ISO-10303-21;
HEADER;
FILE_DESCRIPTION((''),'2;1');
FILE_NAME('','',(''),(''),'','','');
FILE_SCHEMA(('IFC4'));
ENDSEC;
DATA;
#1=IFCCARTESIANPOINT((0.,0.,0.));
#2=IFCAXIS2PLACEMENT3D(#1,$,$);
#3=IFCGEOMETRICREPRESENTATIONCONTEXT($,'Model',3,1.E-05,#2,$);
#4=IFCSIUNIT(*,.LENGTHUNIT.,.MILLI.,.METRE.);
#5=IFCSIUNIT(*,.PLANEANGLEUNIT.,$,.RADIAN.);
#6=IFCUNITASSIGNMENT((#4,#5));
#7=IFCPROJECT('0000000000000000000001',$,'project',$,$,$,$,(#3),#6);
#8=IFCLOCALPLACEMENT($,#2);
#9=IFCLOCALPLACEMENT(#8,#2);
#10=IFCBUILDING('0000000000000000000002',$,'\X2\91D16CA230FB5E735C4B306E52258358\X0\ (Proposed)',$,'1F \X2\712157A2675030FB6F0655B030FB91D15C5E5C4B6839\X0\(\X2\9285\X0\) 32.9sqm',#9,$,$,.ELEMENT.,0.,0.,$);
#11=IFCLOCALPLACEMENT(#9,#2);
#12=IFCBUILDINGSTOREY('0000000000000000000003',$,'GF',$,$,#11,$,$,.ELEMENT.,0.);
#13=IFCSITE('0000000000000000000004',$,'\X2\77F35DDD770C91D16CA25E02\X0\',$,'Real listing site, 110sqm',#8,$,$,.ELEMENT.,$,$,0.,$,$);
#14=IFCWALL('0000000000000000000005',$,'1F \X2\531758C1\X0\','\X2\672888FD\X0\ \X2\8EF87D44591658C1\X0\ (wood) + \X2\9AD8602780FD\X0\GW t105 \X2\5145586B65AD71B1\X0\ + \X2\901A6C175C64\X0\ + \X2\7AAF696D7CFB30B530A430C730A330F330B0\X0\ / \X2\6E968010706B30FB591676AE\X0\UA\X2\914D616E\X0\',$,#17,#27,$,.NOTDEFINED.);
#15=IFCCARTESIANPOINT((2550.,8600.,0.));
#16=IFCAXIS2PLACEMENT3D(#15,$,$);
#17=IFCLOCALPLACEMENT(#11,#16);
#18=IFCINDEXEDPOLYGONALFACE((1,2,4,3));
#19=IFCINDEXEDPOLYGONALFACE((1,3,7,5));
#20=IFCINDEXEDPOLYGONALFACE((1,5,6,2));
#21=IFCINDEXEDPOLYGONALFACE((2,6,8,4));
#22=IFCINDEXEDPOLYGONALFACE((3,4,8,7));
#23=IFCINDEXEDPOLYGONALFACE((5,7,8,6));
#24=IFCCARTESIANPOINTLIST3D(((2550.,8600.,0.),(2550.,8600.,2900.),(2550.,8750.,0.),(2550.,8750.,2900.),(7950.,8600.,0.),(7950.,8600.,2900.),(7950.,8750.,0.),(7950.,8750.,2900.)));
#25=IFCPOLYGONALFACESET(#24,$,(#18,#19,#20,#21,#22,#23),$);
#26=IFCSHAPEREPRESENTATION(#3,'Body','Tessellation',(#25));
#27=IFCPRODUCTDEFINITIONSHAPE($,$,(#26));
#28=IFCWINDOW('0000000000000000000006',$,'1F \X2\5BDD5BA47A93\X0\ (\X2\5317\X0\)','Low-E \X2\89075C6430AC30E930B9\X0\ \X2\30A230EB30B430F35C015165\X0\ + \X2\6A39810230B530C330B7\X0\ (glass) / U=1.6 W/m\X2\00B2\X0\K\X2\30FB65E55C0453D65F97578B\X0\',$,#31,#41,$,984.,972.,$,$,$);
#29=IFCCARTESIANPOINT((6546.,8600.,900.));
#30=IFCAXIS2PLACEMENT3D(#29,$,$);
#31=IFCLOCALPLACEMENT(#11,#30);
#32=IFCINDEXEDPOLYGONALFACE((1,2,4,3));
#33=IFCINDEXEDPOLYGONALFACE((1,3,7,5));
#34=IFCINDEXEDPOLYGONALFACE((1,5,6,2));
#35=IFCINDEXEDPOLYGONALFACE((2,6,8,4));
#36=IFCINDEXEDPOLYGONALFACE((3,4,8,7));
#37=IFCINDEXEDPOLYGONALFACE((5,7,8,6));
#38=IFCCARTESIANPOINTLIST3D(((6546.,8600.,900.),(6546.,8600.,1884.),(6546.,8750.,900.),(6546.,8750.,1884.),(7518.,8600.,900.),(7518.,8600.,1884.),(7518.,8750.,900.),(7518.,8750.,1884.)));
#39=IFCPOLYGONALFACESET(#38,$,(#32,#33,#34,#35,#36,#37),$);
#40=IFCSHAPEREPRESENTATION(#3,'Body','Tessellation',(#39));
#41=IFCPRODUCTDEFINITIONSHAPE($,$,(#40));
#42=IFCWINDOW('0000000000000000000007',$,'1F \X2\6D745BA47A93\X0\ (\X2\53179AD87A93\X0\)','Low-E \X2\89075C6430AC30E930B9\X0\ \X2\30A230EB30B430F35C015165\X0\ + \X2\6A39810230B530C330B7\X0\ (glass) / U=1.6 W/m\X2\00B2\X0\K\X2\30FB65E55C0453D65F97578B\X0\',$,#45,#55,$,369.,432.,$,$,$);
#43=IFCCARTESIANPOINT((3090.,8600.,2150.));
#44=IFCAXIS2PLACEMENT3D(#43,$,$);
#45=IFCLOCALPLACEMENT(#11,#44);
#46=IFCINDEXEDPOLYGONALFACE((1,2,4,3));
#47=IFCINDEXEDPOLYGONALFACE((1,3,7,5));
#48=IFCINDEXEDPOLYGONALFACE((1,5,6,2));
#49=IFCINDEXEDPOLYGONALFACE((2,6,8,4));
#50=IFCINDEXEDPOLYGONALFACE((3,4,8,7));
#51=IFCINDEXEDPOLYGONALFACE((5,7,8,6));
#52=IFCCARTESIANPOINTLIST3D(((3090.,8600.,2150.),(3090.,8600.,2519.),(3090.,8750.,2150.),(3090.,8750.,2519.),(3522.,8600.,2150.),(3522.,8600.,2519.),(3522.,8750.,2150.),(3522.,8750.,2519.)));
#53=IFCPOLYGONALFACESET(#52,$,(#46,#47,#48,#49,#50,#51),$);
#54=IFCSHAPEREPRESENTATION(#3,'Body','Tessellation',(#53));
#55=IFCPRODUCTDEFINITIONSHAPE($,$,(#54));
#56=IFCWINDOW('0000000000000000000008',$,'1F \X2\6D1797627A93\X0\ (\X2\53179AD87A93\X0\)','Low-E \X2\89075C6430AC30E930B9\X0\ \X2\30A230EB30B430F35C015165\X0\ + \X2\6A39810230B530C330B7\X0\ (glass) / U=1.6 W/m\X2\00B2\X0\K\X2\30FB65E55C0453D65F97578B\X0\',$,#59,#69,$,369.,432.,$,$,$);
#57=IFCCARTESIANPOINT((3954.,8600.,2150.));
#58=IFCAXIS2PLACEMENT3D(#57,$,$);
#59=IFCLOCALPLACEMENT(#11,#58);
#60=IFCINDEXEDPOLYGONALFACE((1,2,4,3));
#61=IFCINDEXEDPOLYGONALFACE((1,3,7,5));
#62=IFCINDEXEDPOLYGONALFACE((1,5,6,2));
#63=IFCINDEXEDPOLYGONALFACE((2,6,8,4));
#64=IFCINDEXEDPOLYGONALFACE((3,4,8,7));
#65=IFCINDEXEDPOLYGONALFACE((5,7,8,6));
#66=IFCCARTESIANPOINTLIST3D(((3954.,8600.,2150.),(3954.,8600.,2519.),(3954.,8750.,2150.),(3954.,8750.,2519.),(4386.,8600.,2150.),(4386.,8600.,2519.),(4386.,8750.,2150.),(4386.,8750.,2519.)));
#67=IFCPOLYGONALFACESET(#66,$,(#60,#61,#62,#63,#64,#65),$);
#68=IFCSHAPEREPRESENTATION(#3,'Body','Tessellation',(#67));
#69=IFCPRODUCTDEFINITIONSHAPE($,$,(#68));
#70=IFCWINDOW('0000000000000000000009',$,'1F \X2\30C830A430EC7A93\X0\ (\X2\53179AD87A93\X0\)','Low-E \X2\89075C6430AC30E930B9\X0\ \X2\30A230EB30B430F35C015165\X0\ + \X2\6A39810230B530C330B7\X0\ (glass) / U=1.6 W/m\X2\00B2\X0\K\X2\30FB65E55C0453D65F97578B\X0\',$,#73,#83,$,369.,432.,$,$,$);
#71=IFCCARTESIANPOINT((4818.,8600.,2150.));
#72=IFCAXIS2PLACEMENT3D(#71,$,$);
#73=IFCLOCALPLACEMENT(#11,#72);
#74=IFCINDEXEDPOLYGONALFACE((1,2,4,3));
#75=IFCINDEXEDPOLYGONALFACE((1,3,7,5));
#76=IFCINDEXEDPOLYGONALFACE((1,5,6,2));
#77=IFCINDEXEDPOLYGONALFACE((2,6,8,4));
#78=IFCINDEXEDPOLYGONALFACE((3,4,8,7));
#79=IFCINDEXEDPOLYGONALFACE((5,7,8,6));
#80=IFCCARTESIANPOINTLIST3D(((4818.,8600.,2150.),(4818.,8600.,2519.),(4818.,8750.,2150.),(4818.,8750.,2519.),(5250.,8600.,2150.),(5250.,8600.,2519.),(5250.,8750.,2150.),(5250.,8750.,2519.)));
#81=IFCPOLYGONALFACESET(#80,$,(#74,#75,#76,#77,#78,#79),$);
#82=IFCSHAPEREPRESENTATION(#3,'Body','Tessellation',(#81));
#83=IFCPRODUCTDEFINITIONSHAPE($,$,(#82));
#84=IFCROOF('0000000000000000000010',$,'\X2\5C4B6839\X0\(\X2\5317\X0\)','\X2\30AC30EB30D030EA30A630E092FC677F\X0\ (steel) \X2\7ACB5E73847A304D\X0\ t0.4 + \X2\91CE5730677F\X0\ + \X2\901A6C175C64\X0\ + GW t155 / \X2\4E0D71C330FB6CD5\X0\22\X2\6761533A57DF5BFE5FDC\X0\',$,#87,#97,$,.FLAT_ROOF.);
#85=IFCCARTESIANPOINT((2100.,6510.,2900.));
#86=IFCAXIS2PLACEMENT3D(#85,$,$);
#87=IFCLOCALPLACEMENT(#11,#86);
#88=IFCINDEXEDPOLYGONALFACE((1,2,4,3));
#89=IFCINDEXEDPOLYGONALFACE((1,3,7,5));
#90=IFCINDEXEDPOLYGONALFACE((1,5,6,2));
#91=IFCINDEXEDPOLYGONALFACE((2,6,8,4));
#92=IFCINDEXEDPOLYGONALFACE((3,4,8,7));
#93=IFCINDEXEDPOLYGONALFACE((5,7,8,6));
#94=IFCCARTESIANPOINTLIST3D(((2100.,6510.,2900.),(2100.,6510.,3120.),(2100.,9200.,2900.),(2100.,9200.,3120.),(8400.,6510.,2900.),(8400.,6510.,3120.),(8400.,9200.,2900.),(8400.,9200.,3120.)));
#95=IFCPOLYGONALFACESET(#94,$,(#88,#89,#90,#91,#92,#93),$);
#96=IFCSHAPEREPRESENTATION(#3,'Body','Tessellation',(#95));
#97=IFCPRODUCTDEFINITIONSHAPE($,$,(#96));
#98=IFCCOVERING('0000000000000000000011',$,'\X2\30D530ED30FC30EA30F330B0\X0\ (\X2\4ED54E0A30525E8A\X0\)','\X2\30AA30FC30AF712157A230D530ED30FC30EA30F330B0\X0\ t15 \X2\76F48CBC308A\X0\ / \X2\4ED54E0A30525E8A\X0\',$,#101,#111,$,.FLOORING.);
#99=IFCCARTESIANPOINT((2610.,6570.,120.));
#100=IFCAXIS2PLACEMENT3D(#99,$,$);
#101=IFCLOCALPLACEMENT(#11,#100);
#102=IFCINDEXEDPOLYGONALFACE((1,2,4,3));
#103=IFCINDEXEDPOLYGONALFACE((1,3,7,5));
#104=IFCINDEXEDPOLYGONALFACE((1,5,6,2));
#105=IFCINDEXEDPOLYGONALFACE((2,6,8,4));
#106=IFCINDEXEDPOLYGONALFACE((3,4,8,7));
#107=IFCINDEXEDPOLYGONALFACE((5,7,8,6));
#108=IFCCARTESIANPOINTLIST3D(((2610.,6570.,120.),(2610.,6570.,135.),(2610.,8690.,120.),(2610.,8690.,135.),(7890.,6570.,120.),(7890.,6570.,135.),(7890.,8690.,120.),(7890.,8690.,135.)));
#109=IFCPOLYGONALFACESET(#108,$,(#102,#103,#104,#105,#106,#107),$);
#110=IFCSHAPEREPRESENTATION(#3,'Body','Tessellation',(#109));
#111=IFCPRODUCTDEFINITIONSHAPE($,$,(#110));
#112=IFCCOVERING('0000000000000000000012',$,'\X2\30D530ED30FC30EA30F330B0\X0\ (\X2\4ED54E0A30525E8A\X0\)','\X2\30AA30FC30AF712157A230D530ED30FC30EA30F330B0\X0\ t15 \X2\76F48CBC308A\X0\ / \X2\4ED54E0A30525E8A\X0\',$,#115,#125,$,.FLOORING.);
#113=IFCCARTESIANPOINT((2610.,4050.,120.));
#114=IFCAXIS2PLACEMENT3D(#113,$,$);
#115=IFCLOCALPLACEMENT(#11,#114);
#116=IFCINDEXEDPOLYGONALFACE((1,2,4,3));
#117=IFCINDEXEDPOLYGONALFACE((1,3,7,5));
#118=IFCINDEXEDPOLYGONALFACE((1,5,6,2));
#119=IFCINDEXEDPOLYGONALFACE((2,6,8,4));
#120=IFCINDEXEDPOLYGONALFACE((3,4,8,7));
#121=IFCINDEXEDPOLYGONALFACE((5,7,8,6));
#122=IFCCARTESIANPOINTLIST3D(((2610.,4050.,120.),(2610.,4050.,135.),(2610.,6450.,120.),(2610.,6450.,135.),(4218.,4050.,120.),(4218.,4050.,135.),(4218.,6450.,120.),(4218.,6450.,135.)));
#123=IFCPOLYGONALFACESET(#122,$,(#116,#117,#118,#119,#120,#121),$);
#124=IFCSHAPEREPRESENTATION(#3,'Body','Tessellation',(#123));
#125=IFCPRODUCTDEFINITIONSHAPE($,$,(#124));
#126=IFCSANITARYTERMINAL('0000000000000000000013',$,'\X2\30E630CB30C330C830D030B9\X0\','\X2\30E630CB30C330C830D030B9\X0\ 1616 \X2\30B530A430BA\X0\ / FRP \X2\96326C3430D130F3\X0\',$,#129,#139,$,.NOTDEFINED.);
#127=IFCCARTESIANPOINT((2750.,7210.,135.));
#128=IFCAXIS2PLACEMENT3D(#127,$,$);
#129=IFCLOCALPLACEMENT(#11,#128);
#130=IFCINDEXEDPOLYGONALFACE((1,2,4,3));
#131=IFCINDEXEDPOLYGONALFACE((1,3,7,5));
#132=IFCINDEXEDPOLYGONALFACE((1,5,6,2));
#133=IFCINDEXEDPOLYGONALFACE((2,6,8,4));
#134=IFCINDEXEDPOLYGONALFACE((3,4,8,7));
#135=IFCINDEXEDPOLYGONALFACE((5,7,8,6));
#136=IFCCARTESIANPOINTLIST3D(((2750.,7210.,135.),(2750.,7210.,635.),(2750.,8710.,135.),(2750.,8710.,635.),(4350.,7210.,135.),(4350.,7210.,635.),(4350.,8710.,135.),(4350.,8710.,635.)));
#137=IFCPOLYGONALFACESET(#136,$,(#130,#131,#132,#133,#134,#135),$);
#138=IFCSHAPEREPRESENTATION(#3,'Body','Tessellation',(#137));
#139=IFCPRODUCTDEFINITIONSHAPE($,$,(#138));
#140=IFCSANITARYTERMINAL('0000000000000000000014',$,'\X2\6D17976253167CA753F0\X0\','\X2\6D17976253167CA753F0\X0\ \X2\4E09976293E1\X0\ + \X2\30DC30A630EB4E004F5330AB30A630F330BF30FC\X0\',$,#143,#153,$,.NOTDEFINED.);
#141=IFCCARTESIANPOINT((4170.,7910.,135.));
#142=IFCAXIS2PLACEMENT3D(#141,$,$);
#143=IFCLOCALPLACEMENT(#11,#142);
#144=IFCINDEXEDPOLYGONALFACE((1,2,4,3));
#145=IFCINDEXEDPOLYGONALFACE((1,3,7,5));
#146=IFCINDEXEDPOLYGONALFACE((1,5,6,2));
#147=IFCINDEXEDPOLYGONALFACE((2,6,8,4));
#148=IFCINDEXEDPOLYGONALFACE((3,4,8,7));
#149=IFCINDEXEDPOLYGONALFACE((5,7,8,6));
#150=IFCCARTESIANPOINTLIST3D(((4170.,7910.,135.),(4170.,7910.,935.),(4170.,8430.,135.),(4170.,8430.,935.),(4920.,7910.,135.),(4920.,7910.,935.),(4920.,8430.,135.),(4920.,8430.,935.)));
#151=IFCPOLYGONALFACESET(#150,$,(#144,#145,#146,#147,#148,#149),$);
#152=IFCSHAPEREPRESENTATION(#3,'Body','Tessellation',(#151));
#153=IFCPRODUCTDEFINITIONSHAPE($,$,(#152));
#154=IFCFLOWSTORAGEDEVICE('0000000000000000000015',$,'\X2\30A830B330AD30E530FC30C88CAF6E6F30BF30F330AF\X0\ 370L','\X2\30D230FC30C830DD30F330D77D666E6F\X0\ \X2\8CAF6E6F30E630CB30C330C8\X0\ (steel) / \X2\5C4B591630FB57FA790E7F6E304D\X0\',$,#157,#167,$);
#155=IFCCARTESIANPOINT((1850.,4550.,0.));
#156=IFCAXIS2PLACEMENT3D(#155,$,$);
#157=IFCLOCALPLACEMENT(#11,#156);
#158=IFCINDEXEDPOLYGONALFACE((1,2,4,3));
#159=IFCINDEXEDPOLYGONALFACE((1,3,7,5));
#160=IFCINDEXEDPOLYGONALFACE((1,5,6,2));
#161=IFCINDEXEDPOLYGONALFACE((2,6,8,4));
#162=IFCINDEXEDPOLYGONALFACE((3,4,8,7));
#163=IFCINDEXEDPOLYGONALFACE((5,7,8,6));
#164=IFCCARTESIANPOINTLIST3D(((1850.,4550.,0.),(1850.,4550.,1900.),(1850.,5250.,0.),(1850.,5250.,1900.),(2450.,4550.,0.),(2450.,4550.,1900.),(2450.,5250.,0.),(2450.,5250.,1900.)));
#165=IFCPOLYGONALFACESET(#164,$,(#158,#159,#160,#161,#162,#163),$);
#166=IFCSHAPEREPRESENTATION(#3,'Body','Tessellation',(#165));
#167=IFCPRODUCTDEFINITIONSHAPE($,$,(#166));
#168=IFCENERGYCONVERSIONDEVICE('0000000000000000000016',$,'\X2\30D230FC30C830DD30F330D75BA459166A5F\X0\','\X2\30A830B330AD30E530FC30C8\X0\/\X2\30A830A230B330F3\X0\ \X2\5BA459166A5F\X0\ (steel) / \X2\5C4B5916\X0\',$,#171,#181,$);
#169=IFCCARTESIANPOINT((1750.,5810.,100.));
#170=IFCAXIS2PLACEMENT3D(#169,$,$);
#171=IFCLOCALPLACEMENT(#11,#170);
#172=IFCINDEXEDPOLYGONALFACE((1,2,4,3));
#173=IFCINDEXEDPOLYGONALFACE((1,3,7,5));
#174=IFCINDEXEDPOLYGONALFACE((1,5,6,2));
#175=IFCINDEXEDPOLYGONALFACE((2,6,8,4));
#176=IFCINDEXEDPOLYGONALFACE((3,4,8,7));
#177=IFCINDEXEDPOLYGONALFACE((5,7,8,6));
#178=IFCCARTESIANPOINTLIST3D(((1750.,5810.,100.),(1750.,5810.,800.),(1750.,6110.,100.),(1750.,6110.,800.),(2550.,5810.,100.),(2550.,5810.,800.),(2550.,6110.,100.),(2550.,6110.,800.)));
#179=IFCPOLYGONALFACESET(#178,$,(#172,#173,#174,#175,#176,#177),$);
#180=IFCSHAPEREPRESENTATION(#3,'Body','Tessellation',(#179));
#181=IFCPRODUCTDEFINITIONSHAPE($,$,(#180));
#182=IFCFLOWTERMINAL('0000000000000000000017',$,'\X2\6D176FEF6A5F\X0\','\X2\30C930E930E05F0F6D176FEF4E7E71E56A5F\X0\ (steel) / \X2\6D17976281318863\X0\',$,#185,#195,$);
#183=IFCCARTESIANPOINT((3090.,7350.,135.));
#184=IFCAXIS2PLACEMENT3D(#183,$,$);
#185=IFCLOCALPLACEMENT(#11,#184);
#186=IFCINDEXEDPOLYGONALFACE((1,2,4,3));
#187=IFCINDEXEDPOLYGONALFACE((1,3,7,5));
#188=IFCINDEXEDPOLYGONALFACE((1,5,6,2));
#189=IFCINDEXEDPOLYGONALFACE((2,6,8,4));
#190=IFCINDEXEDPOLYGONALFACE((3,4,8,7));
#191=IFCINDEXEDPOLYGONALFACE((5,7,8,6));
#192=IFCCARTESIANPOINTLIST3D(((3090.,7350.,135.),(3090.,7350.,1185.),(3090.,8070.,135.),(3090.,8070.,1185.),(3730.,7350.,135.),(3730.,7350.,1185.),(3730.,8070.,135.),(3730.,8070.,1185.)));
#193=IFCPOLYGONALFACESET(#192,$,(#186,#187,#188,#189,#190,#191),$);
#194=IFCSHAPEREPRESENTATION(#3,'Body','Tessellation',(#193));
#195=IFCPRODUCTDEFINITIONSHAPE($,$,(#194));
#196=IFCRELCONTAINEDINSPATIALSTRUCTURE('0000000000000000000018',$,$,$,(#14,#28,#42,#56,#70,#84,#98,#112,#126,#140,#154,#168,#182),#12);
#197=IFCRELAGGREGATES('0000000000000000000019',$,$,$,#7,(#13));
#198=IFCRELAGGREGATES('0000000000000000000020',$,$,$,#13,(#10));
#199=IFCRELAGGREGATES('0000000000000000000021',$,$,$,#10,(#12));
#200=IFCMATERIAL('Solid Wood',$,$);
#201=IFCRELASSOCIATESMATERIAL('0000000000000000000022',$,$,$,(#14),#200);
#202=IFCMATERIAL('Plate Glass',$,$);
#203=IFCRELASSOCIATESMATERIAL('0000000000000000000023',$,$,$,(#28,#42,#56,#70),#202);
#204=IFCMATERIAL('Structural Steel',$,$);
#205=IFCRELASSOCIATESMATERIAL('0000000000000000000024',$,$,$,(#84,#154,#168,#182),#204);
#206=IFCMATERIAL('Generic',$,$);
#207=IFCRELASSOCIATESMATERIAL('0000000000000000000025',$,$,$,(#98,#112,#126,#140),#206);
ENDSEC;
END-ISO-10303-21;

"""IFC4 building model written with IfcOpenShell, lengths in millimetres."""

from ifc_helpers import new_model, si_unit, frame, frame_2d, origin, place, context, project, spatial, rectangle, extrude, material, element, fill, save


model = new_model("IFC4")

# Units and contexts
model_context = context("Model", 3, precision=1e-05, world=origin())
ifc_project = project(units=[si_unit("LENGTHUNIT", "METRE", prefix="MILLI"), si_unit("PLANEANGLEUNIT", "RADIAN")], contexts=[model_context])

# Site, building, storey
site_placement = place(None, origin())
site = spatial("IfcSite", under=ifc_project, at=site_placement, Name="石川県金沢市", ObjectType="Real listing site, 110sqm", CompositionType="ELEMENT", RefElevation=0.0)
building_placement = place(site_placement, origin())
building = spatial("IfcBuilding", under=site, at=building_placement, Name="金沢・平屋の別荘 (Proposed)", ObjectType="1F 無垢材・漆喰・金属屋根(銅) 32.9sqm", CompositionType="ELEMENT", ElevationOfRefHeight=0.0, ElevationOfTerrain=0.0)
storey_placement = place(building_placement, origin())
storey = spatial("IfcBuildingStorey", under=building, at=storey_placement, Name="GF", CompositionType="ELEMENT", Elevation=0.0)

# Shared definitions
ifc_material_1 = material(Name="Solid Wood")

# Wall, openings, windows
wall_1_placement = place(storey_placement, frame((2550.0, 8600.0, 0.0)))
wall_1 = element("IfcWall", 1, at=wall_1_placement, inside=storey, material=ifc_material_1, Name="1F 北壁", Description="木製 軸組外壁 (wood) + 高性能GW t105 充填断熱 + 通気層 + 窯業系サイディング / 準耐火・外皮UA配慮", PredefinedType="NOTDEFINED", context=model_context, shape_type="SweptSolid", body=[
    extrude(rectangle(XDim=5400.0, YDim=150.0, at=frame_2d((2700.0, 75.0))), frame((2550.0, 8600.0, 0.0)), (0.0, 0.0, 1.0), 2900.0),
])
opening_1_placement = place(storey_placement, frame((6546.0, 8600.0, 900.0)))
opening_1 = element("IfcOpeningElement", 2, at=opening_1_placement, cuts=wall_1, PredefinedType="NOTDEFINED", context=model_context, shape_type="SweptSolid", body=[
    extrude(rectangle(XDim=972.0, YDim=150.0, at=frame_2d((486.0, 75.0))), frame((6546.0, 8600.0, 900.0)), (0.0, 0.0, 1.0), 984.0),
])
opening_2_placement = place(storey_placement, frame((3090.0, 8600.0, 2150.0)))
opening_2 = element("IfcOpeningElement", 3, at=opening_2_placement, cuts=wall_1, PredefinedType="NOTDEFINED", context=model_context, shape_type="SweptSolid", body=[
    extrude(rectangle(XDim=432.0, YDim=150.0, at=frame_2d((216.0, 75.0))), frame((3090.0, 8600.0, 2150.0)), (0.0, 0.0, 1.0), 369.0),
])
opening_3_placement = place(storey_placement, frame((3954.0, 8600.0, 2150.0)))
opening_3 = element("IfcOpeningElement", 4, at=opening_3_placement, cuts=wall_1, PredefinedType="NOTDEFINED", context=model_context, shape_type="SweptSolid", body=[
    extrude(rectangle(XDim=432.0, YDim=150.0, at=frame_2d((216.0, 75.0))), frame((3954.0, 8600.0, 2150.0)), (0.0, 0.0, 1.0), 369.0),
])
opening_4_placement = place(storey_placement, frame((4818.0, 8600.0, 2150.0)))
opening_4 = element("IfcOpeningElement", 5, at=opening_4_placement, cuts=wall_1, PredefinedType="NOTDEFINED", context=model_context, shape_type="SweptSolid", body=[
    extrude(rectangle(XDim=432.0, YDim=150.0, at=frame_2d((216.0, 75.0))), frame((4818.0, 8600.0, 2150.0)), (0.0, 0.0, 1.0), 369.0),
])
ifc_material_2 = material(Name="Plate Glass")
window_1_placement = place(storey_placement, frame((6546.0, 8600.0, 900.0)))
window_1 = element("IfcWindow", 6, at=window_1_placement, inside=storey, material=ifc_material_2, Name="1F 寝室窓 (北)", Description="Low-E 複層ガラス アルゴン封入 + 樹脂サッシ (glass) / U=1.6 W/m²K・日射取得型", OverallHeight=984.0, OverallWidth=972.0, context=model_context, shape_type="SweptSolid", body=[
    extrude(rectangle(XDim=972.0, YDim=150.0, at=frame_2d((486.0, 75.0))), frame((6546.0, 8600.0, 900.0)), (0.0, 0.0, 1.0), 984.0),
])
fill(opening_1, window_1)
window_2_placement = place(storey_placement, frame((3090.0, 8600.0, 2150.0)))
window_2 = element("IfcWindow", 7, at=window_2_placement, inside=storey, material=ifc_material_2, Name="1F 浴室窓 (北高窓)", Description="Low-E 複層ガラス アルゴン封入 + 樹脂サッシ (glass) / U=1.6 W/m²K・日射取得型", OverallHeight=369.0, OverallWidth=432.0, context=model_context, shape_type="SweptSolid", body=[
    extrude(rectangle(XDim=432.0, YDim=150.0, at=frame_2d((216.0, 75.0))), frame((3090.0, 8600.0, 2150.0)), (0.0, 0.0, 1.0), 369.0),
])
fill(opening_2, window_2)
window_3_placement = place(storey_placement, frame((3954.0, 8600.0, 2150.0)))
window_3 = element("IfcWindow", 8, at=window_3_placement, inside=storey, material=ifc_material_2, Name="1F 洗面窓 (北高窓)", Description="Low-E 複層ガラス アルゴン封入 + 樹脂サッシ (glass) / U=1.6 W/m²K・日射取得型", OverallHeight=369.0, OverallWidth=432.0, context=model_context, shape_type="SweptSolid", body=[
    extrude(rectangle(XDim=432.0, YDim=150.0, at=frame_2d((216.0, 75.0))), frame((3954.0, 8600.0, 2150.0)), (0.0, 0.0, 1.0), 369.0),
])
fill(opening_3, window_3)
window_4_placement = place(storey_placement, frame((4818.0, 8600.0, 2150.0)))
window_4 = element("IfcWindow", 9, at=window_4_placement, inside=storey, material=ifc_material_2, Name="1F トイレ窓 (北高窓)", Description="Low-E 複層ガラス アルゴン封入 + 樹脂サッシ (glass) / U=1.6 W/m²K・日射取得型", OverallHeight=369.0, OverallWidth=432.0, context=model_context, shape_type="SweptSolid", body=[
    extrude(rectangle(XDim=432.0, YDim=150.0, at=frame_2d((216.0, 75.0))), frame((4818.0, 8600.0, 2150.0)), (0.0, 0.0, 1.0), 369.0),
])
fill(opening_4, window_4)

# Roof
ifc_material_3 = material(Name="Structural Steel")
roof_placement = place(storey_placement, frame((2100.0, 6510.0, 2900.0)))
element("IfcRoof", 10, at=roof_placement, inside=storey, material=ifc_material_3, Name="屋根(北)", Description="ガルバリウム鋼板 (steel) 立平葺き t0.4 + 野地板 + 通気層 + GW t155 / 不燃・法22条区域対応", PredefinedType="FLAT_ROOF", context=model_context, shape_type="SweptSolid", body=[
    extrude(rectangle(XDim=6300.0, YDim=2690.0, at=frame_2d((3150.0, 1345.0))), frame((2100.0, 6510.0, 2900.0)), (0.0, 0.0, 1.0), 220.0),
])

# Coverings
ifc_material_4 = material(Name="Generic")
covering_1_placement = place(storey_placement, frame((2610.0, 6570.0, 120.0)))
element("IfcCovering", 11, at=covering_1_placement, inside=storey, material=ifc_material_4, Name="フローリング (仕上げ床)", Description="オーク無垢フローリング t15 直貼り / 仕上げ床", PredefinedType="FLOORING", context=model_context, shape_type="SweptSolid", body=[
    extrude(rectangle(XDim=5280.0, YDim=2120.0, at=frame_2d((2640.0, 1060.0))), frame((2610.0, 6570.0, 120.0)), (0.0, 0.0, 1.0), 15.0),
])
covering_2_placement = place(storey_placement, frame((2610.0, 4050.0, 120.0)))
element("IfcCovering", 12, at=covering_2_placement, inside=storey, material=ifc_material_4, Name="フローリング (仕上げ床)", Description="オーク無垢フローリング t15 直貼り / 仕上げ床", PredefinedType="FLOORING", context=model_context, shape_type="SweptSolid", body=[
    extrude(rectangle(XDim=1608.0, YDim=2400.0, at=frame_2d((804.0, 1200.0))), frame((2610.0, 4050.0, 120.0)), (0.0, 0.0, 1.0), 15.0),
])

# Sanitary terminals
sanitary_terminal_1_placement = place(storey_placement, frame((2750.0, 7210.0, 135.0)))
element("IfcSanitaryTerminal", 13, at=sanitary_terminal_1_placement, inside=storey, material=ifc_material_4, Name="ユニットバス", Description="ユニットバス 1616 サイズ / FRP 防水パン", PredefinedType="NOTDEFINED", context=model_context, shape_type="SweptSolid", body=[
    extrude(rectangle(XDim=1600.0, YDim=1500.0, at=frame_2d((800.0, 750.0))), frame((2750.0, 7210.0, 135.0)), (0.0, 0.0, 1.0), 500.0),
])
sanitary_terminal_2_placement = place(storey_placement, frame((4170.0, 7910.0, 135.0)))
element("IfcSanitaryTerminal", 14, at=sanitary_terminal_2_placement, inside=storey, material=ifc_material_4, Name="洗面化粧台", Description="洗面化粧台 三面鏡 + ボウル一体カウンター", PredefinedType="NOTDEFINED", context=model_context, shape_type="SweptSolid", body=[
    extrude(rectangle(XDim=750.0, YDim=520.0, at=frame_2d((375.0, 260.0))), frame((4170.0, 7910.0, 135.0)), (0.0, 0.0, 1.0), 800.0),
])

# Flow storage device
flow_storage_device_placement = place(storey_placement, frame((1850.0, 4550.0, 0.0)))
element("IfcFlowStorageDevice", 15, at=flow_storage_device_placement, inside=storey, material=ifc_material_3, Name="エコキュート貯湯タンク 370L", Description="ヒートポンプ給湯 貯湯ユニット (steel) / 屋外・基礎置き", context=model_context, shape_type="SweptSolid", body=[
    extrude(rectangle(XDim=600.0, YDim=700.0, at=frame_2d((300.0, 350.0))), frame((1850.0, 4550.0, 0.0)), (0.0, 0.0, 1.0), 1900.0),
])

# Energy conversion device
energy_conversion_device_placement = place(storey_placement, frame((1750.0, 5810.0, 100.0)))
element("IfcEnergyConversionDevice", 16, at=energy_conversion_device_placement, inside=storey, material=ifc_material_3, Name="ヒートポンプ室外機", Description="エコキュート/エアコン 室外機 (steel) / 屋外", context=model_context, shape_type="SweptSolid", body=[
    extrude(rectangle(XDim=800.0, YDim=300.0, at=frame_2d((400.0, 150.0))), frame((1750.0, 5810.0, 100.0)), (0.0, 0.0, 1.0), 700.0),
])

# Flow terminal
flow_terminal_placement = place(storey_placement, frame((3090.0, 7350.0, 135.0)))
element("IfcFlowTerminal", 17, at=flow_terminal_placement, inside=storey, material=ifc_material_3, Name="洗濯機", Description="ドラム式洗濯乾燥機 (steel) / 洗面脱衣", context=model_context, shape_type="SweptSolid", body=[
    extrude(rectangle(XDim=640.0, YDim=720.0, at=frame_2d((320.0, 360.0))), frame((3090.0, 7350.0, 135.0)), (0.0, 0.0, 1.0), 1050.0),
])

save(model, "model.ifc")
